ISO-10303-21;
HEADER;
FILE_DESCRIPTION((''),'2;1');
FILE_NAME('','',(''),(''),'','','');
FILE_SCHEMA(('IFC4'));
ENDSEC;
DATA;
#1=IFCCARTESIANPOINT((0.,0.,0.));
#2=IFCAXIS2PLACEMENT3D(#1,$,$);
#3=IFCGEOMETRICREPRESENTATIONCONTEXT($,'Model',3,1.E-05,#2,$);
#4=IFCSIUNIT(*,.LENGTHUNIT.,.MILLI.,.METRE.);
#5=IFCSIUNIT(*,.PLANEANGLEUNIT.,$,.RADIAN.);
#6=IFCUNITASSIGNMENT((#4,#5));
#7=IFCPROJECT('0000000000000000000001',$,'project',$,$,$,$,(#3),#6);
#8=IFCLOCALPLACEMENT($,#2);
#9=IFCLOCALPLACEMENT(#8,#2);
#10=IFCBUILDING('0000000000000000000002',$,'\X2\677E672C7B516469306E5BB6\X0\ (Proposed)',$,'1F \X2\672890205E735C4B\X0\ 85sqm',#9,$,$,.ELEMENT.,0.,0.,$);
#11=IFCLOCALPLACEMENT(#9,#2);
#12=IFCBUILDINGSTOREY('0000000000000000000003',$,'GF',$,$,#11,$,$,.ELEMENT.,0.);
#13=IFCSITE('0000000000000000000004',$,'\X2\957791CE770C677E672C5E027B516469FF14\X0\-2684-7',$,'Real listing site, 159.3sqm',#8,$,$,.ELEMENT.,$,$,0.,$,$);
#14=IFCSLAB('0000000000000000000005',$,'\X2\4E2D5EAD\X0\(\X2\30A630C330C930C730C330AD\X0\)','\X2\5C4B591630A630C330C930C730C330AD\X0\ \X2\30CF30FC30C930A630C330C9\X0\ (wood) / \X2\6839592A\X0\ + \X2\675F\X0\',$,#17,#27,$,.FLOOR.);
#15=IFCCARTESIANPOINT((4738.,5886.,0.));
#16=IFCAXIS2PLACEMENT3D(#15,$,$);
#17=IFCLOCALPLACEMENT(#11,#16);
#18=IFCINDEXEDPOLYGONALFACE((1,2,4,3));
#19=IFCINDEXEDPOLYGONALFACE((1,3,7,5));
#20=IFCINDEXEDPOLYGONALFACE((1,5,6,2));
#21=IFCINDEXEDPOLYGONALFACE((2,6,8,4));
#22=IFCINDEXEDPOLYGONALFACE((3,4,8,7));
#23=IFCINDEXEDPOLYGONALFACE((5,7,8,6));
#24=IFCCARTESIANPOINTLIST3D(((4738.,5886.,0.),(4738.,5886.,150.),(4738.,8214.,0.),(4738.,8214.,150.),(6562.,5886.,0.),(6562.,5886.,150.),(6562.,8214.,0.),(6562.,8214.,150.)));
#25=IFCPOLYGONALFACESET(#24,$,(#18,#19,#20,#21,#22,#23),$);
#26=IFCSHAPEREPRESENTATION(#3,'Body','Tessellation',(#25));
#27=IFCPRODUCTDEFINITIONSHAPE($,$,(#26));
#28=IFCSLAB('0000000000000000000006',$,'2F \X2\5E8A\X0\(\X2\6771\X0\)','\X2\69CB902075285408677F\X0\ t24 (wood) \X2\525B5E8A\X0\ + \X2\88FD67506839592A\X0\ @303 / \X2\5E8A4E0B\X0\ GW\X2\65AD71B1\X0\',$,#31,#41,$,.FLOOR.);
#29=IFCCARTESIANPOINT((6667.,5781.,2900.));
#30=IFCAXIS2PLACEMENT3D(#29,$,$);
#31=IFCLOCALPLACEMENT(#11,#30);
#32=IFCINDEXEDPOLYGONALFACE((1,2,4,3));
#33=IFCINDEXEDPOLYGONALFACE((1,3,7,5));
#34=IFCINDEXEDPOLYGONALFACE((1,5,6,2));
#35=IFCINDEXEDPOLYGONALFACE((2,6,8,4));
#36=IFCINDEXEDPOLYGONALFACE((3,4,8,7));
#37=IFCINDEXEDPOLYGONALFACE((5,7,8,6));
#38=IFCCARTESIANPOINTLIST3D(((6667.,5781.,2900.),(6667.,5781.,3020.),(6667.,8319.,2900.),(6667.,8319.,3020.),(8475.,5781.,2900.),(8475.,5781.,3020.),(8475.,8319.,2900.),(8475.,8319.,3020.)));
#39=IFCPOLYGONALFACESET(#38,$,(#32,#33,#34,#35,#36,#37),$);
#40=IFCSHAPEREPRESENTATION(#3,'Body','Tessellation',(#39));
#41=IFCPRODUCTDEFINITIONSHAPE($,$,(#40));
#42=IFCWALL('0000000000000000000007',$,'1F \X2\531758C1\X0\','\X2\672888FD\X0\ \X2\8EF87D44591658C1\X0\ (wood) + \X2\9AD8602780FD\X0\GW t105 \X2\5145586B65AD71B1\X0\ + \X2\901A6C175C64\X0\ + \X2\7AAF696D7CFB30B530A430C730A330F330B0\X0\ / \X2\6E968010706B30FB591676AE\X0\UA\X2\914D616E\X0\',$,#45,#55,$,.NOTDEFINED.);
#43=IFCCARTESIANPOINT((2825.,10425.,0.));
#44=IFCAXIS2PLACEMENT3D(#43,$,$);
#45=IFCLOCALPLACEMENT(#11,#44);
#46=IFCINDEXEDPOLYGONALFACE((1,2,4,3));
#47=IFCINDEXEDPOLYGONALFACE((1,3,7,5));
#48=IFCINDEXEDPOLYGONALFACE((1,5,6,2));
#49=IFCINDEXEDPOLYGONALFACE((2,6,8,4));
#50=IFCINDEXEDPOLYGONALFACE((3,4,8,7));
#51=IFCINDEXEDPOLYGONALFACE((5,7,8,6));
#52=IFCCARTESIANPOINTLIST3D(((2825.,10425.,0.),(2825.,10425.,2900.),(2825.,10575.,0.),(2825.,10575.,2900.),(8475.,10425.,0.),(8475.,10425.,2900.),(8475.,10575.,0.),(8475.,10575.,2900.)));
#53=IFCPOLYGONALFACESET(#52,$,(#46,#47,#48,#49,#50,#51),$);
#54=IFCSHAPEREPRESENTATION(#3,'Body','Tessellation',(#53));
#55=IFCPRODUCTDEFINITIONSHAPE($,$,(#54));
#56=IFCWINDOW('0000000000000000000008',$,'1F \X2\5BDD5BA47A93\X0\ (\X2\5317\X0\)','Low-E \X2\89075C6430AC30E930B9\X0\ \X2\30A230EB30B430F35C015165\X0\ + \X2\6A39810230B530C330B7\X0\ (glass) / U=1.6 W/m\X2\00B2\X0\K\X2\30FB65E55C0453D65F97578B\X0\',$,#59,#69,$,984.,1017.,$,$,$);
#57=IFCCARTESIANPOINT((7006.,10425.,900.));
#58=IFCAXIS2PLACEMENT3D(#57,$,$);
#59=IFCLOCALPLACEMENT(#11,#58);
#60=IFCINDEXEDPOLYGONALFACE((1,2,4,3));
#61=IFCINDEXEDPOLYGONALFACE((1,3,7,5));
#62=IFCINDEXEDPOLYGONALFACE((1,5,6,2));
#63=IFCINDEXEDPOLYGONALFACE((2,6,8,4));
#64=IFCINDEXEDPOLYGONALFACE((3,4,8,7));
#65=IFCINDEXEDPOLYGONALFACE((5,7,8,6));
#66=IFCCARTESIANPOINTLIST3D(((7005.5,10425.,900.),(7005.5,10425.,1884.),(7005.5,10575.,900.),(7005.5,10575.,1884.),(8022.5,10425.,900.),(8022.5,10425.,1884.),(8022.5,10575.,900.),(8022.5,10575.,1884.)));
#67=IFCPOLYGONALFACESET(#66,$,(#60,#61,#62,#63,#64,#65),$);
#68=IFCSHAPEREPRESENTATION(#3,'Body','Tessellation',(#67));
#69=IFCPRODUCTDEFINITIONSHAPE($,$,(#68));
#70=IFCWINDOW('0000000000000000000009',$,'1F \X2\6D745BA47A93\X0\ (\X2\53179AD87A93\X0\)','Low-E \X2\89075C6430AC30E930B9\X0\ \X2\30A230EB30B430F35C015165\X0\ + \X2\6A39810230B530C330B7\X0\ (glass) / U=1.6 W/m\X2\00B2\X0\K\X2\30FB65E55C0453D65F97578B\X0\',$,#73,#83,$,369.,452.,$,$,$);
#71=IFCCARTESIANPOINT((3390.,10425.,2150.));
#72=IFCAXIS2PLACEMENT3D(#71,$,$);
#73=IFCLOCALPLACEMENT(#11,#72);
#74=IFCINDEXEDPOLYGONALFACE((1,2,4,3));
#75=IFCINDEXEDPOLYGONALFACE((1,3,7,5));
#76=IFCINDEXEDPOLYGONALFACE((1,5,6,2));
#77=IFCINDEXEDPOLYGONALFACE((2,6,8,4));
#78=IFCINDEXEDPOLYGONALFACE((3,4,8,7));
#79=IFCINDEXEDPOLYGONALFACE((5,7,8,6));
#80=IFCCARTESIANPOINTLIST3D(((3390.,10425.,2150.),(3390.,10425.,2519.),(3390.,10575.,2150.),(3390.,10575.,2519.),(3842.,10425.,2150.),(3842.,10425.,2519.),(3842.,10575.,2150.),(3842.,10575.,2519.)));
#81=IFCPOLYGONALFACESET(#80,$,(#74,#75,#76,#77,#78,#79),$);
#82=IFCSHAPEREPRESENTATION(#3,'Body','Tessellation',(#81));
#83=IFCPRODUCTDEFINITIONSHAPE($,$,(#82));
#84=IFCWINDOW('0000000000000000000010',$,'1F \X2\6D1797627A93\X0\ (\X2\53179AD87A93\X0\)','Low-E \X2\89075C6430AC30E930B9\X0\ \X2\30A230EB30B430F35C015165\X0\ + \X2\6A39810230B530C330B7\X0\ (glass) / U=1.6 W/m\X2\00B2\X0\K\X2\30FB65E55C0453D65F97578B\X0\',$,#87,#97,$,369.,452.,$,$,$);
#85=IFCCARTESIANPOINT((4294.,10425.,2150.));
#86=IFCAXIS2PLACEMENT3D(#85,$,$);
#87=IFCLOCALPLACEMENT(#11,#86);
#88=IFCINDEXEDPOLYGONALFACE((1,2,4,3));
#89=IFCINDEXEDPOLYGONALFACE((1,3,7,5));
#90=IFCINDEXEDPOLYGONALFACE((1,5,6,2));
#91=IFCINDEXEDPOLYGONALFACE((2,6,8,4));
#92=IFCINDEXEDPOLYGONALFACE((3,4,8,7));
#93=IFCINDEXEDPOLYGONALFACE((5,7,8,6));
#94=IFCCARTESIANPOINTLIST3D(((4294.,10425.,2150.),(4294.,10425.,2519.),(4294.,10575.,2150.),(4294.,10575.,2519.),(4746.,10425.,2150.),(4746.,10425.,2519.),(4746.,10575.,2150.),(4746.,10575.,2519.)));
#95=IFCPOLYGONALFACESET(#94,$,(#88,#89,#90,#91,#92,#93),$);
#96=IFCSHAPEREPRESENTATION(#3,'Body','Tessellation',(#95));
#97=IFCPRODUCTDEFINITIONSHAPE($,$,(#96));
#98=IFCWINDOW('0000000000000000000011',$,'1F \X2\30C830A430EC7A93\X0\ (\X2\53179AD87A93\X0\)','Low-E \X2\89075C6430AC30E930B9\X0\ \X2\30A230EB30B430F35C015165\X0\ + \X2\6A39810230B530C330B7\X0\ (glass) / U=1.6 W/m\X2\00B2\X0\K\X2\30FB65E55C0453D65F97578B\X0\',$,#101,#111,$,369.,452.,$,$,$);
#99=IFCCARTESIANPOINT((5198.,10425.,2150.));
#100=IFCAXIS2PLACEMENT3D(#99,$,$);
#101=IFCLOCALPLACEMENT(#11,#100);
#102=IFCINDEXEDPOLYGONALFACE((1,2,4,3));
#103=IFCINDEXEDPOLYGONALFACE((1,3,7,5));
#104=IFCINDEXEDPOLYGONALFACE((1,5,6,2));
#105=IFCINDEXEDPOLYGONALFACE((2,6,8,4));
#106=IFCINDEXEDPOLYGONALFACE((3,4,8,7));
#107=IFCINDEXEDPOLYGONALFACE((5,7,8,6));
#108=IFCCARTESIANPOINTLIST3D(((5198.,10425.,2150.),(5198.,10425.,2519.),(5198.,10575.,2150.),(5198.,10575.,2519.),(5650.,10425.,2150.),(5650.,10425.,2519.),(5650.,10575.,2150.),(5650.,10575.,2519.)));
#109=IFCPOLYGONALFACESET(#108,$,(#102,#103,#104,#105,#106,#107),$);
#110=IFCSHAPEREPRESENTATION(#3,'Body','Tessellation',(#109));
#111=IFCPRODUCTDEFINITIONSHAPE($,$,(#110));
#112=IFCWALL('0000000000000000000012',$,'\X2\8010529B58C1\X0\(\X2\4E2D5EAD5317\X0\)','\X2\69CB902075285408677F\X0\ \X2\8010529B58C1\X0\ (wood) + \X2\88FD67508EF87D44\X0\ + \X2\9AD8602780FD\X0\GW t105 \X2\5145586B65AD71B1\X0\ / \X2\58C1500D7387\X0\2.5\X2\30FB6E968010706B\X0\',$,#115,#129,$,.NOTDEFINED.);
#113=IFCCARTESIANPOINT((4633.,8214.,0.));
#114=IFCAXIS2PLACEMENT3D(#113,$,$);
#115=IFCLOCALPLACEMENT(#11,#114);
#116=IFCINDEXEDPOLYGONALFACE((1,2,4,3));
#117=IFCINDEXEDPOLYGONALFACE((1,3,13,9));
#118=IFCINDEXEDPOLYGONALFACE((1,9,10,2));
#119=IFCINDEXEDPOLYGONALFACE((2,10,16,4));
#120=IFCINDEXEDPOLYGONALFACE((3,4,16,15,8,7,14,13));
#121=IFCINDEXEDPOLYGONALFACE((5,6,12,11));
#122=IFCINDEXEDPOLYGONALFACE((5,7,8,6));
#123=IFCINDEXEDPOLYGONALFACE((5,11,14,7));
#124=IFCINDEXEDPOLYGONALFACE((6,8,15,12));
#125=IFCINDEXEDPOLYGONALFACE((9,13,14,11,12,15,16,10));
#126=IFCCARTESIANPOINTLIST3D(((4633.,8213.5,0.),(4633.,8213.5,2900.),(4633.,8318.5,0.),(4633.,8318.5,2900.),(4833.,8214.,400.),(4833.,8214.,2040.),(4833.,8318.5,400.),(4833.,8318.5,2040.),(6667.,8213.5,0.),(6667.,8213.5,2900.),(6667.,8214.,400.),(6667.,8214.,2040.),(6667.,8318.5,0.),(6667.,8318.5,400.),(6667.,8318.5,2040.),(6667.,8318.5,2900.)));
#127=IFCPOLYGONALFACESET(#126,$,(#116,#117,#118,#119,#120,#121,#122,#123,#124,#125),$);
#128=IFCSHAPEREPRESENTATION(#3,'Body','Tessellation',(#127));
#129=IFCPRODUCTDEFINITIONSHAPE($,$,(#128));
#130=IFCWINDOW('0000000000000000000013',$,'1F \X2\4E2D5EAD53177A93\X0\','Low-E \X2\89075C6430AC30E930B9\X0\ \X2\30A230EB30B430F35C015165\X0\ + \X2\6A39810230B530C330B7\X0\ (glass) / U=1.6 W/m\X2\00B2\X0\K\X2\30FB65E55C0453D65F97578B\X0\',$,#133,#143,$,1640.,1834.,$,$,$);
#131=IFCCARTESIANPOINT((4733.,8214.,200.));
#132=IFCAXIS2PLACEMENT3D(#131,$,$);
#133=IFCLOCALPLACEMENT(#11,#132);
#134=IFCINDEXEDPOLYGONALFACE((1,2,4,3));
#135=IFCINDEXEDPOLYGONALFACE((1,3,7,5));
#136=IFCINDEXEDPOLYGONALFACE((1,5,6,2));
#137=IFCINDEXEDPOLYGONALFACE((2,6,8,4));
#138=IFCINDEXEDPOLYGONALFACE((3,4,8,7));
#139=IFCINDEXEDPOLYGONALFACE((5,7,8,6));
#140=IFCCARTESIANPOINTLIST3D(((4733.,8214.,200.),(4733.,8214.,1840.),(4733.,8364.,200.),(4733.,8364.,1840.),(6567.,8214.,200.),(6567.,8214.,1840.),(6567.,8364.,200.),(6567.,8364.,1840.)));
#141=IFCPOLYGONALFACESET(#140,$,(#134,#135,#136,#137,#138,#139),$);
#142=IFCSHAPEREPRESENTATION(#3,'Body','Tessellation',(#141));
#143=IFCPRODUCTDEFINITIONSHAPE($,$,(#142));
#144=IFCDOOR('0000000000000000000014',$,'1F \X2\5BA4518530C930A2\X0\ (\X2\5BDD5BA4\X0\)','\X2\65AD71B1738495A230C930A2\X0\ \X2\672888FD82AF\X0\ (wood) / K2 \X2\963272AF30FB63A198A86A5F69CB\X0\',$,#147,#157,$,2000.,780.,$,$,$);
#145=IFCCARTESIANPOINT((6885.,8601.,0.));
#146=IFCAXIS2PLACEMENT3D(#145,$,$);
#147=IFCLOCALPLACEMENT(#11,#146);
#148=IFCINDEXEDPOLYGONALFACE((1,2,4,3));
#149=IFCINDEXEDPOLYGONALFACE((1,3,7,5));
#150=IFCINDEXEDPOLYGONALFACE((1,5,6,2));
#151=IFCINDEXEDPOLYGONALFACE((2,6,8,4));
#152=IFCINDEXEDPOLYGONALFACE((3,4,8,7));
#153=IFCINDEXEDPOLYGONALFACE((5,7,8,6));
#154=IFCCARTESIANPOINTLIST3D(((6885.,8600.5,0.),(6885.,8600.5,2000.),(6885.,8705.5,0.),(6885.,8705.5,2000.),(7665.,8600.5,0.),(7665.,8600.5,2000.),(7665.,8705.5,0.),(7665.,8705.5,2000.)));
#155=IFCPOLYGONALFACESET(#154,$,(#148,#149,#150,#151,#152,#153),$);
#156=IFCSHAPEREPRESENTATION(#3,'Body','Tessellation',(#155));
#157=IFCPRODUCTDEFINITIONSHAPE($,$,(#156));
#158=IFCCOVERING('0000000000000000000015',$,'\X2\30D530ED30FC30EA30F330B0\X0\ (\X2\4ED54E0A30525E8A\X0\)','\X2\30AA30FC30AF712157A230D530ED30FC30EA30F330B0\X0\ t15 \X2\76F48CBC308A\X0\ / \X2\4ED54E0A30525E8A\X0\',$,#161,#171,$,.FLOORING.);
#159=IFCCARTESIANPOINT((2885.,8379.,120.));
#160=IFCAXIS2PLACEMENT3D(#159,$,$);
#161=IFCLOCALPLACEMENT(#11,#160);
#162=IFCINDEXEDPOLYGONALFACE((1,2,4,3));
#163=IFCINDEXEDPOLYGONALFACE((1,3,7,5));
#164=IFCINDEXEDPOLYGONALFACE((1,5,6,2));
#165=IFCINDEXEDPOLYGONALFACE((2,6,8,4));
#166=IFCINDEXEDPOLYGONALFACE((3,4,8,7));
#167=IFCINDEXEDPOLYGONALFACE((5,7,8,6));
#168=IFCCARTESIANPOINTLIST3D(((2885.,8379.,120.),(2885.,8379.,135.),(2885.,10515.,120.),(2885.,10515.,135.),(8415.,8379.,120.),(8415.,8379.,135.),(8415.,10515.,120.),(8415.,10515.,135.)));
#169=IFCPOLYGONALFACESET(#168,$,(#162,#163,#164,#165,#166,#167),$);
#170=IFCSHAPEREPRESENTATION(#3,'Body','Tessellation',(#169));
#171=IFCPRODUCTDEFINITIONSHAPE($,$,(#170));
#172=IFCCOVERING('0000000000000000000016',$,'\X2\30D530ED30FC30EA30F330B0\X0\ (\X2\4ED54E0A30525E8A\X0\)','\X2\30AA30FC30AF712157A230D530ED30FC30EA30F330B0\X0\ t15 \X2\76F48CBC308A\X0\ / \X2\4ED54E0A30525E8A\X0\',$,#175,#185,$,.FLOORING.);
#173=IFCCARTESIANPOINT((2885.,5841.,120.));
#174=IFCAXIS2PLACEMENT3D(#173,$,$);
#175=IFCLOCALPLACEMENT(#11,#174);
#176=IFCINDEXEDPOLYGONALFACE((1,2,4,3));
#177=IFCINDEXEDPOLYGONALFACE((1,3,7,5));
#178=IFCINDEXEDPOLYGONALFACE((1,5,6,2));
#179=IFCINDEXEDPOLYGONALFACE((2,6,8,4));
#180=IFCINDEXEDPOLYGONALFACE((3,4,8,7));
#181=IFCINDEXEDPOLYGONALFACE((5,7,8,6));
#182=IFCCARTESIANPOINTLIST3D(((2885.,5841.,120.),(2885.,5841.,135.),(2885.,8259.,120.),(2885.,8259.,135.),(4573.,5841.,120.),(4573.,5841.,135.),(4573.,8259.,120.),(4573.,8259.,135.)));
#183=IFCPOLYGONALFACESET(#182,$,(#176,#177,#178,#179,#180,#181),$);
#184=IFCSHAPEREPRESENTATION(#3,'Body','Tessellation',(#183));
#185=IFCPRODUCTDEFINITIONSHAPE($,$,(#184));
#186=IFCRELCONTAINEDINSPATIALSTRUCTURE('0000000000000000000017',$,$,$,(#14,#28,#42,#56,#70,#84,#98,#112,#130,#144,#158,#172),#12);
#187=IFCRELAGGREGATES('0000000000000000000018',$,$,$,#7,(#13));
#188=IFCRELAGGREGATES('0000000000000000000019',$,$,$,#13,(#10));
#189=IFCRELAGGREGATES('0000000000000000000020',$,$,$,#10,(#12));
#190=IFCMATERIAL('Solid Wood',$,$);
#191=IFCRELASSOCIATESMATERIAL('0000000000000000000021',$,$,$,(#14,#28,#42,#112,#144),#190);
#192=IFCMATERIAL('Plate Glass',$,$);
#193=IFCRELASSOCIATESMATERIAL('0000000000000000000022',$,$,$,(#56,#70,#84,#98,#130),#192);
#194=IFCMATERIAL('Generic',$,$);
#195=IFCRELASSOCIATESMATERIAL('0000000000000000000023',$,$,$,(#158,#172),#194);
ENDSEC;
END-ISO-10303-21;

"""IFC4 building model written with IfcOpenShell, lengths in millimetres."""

from ifc_helpers import new_model, si_unit, frame, frame_2d, origin, place, context, project, spatial, rectangle, extrude, material, element, fill, save


model = new_model("IFC4")

# Units and contexts
model_context = context("Model", 3, precision=1e-05, world=origin())
ifc_project = project(units=[si_unit("LENGTHUNIT", "METRE", prefix="MILLI"), si_unit("PLANEANGLEUNIT", "RADIAN")], contexts=[model_context])

# Site, building, storey
site_placement = place(None, origin())
site = spatial("IfcSite", under=ifc_project, at=site_placement, Name="長野県松本市筑摩４-2684-7", ObjectType="Real listing site, 159.3sqm", CompositionType="ELEMENT", RefElevation=0.0)
building_placement = place(site_placement, origin())
building = spatial("IfcBuilding", under=site, at=building_placement, Name="松本筑摩の家 (Proposed)", ObjectType="1F 木造平屋 85sqm", CompositionType="ELEMENT", ElevationOfRefHeight=0.0, ElevationOfTerrain=0.0)
storey_placement = place(building_placement, origin())
storey = spatial("IfcBuildingStorey", under=building, at=storey_placement, Name="GF", CompositionType="ELEMENT", Elevation=0.0)

# Slabs
ifc_material_1 = material(Name="Solid Wood")
slab_1_placement = place(storey_placement, frame((4738.0, 5886.0, 0.0)))
element("IfcSlab", 1, at=slab_1_placement, inside=storey, material=ifc_material_1, Name="中庭(ウッドデッキ)", Description="屋外ウッドデッキ ハードウッド (wood) / 根太 + 束", PredefinedType="FLOOR", context=model_context, shape_type="SweptSolid", body=[
    extrude(rectangle(XDim=1824.0, YDim=2328.0, at=frame_2d((912.0, 1164.0))), frame((4738.0, 5886.0, 0.0)), (0.0, 0.0, 1.0), 150.0),
])
slab_2_placement = place(storey_placement, frame((6667.0, 5781.0, 2900.0)))
element("IfcSlab", 2, at=slab_2_placement, inside=storey, material=ifc_material_1, Name="2F 床(東)", Description="構造用合板 t24 (wood) 剛床 + 製材根太 @303 / 床下 GW断熱", PredefinedType="FLOOR", context=model_context, shape_type="SweptSolid", body=[
    extrude(rectangle(XDim=1808.0, YDim=2538.0, at=frame_2d((904.0, 1269.0))), frame((6667.0, 5781.0, 2900.0)), (0.0, 0.0, 1.0), 120.0),
])

# Wall, openings, windows
wall_1_placement = place(storey_placement, frame((2825.0, 10425.0, 0.0)))
wall_1 = element("IfcWall", 3, at=wall_1_placement, inside=storey, material=ifc_material_1, Name="1F 北壁", Description="木製 軸組外壁 (wood) + 高性能GW t105 充填断熱 + 通気層 + 窯業系サイディング / 準耐火・外皮UA配慮", PredefinedType="NOTDEFINED", context=model_context, shape_type="SweptSolid", body=[
    extrude(rectangle(XDim=5650.0, YDim=150.0, at=frame_2d((2825.0, 75.0))), frame((2825.0, 10425.0, 0.0)), (0.0, 0.0, 1.0), 2900.0),
])
opening_1_placement = place(storey_placement, frame((7006.0, 10425.0, 900.0)))
opening_1 = element("IfcOpeningElement", 4, at=opening_1_placement, cuts=wall_1, PredefinedType="NOTDEFINED", context=model_context, shape_type="SweptSolid", body=[
    extrude(rectangle(XDim=1017.0, YDim=150.0, at=frame_2d((508.0, 75.0))), frame((7006.0, 10425.0, 900.0)), (0.0, 0.0, 1.0), 984.0),
])
opening_2_placement = place(storey_placement, frame((3390.0, 10425.0, 2150.0)))
opening_2 = element("IfcOpeningElement", 5, at=opening_2_placement, cuts=wall_1, PredefinedType="NOTDEFINED", context=model_context, shape_type="SweptSolid", body=[
    extrude(rectangle(XDim=452.0, YDim=150.0, at=frame_2d((226.0, 75.0))), frame((3390.0, 10425.0, 2150.0)), (0.0, 0.0, 1.0), 369.0),
])
opening_3_placement = place(storey_placement, frame((4294.0, 10425.0, 2150.0)))
opening_3 = element("IfcOpeningElement", 6, at=opening_3_placement, cuts=wall_1, PredefinedType="NOTDEFINED", context=model_context, shape_type="SweptSolid", body=[
    extrude(rectangle(XDim=452.0, YDim=150.0, at=frame_2d((226.0, 75.0))), frame((4294.0, 10425.0, 2150.0)), (0.0, 0.0, 1.0), 369.0),
])
opening_4_placement = place(storey_placement, frame((5198.0, 10425.0, 2150.0)))
opening_4 = element("IfcOpeningElement", 7, at=opening_4_placement, cuts=wall_1, PredefinedType="NOTDEFINED", context=model_context, shape_type="SweptSolid", body=[
    extrude(rectangle(XDim=452.0, YDim=150.0, at=frame_2d((226.0, 75.0))), frame((5198.0, 10425.0, 2150.0)), (0.0, 0.0, 1.0), 369.0),
])
ifc_material_2 = material(Name="Plate Glass")
window_1_placement = place(storey_placement, frame((7006.0, 10425.0, 900.0)))
window_1 = element("IfcWindow", 8, at=window_1_placement, inside=storey, material=ifc_material_2, Name="1F 寝室窓 (北)", Description="Low-E 複層ガラス アルゴン封入 + 樹脂サッシ (glass) / U=1.6 W/m²K・日射取得型", OverallHeight=984.0, OverallWidth=1017.0, context=model_context, shape_type="SweptSolid", body=[
    extrude(rectangle(XDim=1017.0, YDim=150.0, at=frame_2d((508.0, 75.0))), frame((7006.0, 10425.0, 900.0)), (0.0, 0.0, 1.0), 984.0),
])
fill(opening_1, window_1)
window_2_placement = place(storey_placement, frame((3390.0, 10425.0, 2150.0)))
window_2 = element("IfcWindow", 9, at=window_2_placement, inside=storey, material=ifc_material_2, Name="1F 浴室窓 (北高窓)", Description="Low-E 複層ガラス アルゴン封入 + 樹脂サッシ (glass) / U=1.6 W/m²K・日射取得型", OverallHeight=369.0, OverallWidth=452.0, context=model_context, shape_type="SweptSolid", body=[
    extrude(rectangle(XDim=452.0, YDim=150.0, at=frame_2d((226.0, 75.0))), frame((3390.0, 10425.0, 2150.0)), (0.0, 0.0, 1.0), 369.0),
])
fill(opening_2, window_2)
window_3_placement = place(storey_placement, frame((4294.0, 10425.0, 2150.0)))
window_3 = element("IfcWindow", 10, at=window_3_placement, inside=storey, material=ifc_material_2, Name="1F 洗面窓 (北高窓)", Description="Low-E 複層ガラス アルゴン封入 + 樹脂サッシ (glass) / U=1.6 W/m²K・日射取得型", OverallHeight=369.0, OverallWidth=452.0, context=model_context, shape_type="SweptSolid", body=[
    extrude(rectangle(XDim=452.0, YDim=150.0, at=frame_2d((226.0, 75.0))), frame((4294.0, 10425.0, 2150.0)), (0.0, 0.0, 1.0), 369.0),
])
fill(opening_3, window_3)
window_4_placement = place(storey_placement, frame((5198.0, 10425.0, 2150.0)))
window_4 = element("IfcWindow", 11, at=window_4_placement, inside=storey, material=ifc_material_2, Name="1F トイレ窓 (北高窓)", Description="Low-E 複層ガラス アルゴン封入 + 樹脂サッシ (glass) / U=1.6 W/m²K・日射取得型", OverallHeight=369.0, OverallWidth=452.0, context=model_context, shape_type="SweptSolid", body=[
    extrude(rectangle(XDim=452.0, YDim=150.0, at=frame_2d((226.0, 75.0))), frame((5198.0, 10425.0, 2150.0)), (0.0, 0.0, 1.0), 369.0),
])
fill(opening_4, window_4)

# Wall, opening, window
wall_2_placement = place(storey_placement, frame((4633.0, 8214.0, 0.0)))
wall_2 = element("IfcWall", 12, at=wall_2_placement, inside=storey, material=ifc_material_1, Name="耐力壁(中庭北)", Description="構造用合板 耐力壁 (wood) + 製材軸組 + 高性能GW t105 充填断熱 / 壁倍率2.5・準耐火", PredefinedType="NOTDEFINED", context=model_context, shape_type="SweptSolid", body=[
    extrude(rectangle(XDim=2034.0, YDim=105.0, at=frame_2d((1017.0, 52.0))), frame((4633.0, 8214.0, 0.0)), (0.0, 0.0, 1.0), 2900.0),
])
opening_5_placement = place(storey_placement, frame((4733.0, 8214.0, 200.0)))
opening_5 = element("IfcOpeningElement", 13, at=opening_5_placement, cuts=wall_2, PredefinedType="NOTDEFINED", context=model_context, shape_type="SweptSolid", body=[
    extrude(rectangle(XDim=1834.0, YDim=150.0, at=frame_2d((917.0, 75.0))), frame((4733.0, 8214.0, 200.0)), (0.0, 0.0, 1.0), 1640.0),
])
window_5_placement = place(storey_placement, frame((4733.0, 8214.0, 200.0)))
window_5 = element("IfcWindow", 14, at=window_5_placement, inside=storey, material=ifc_material_2, Name="1F 中庭北窓", Description="Low-E 複層ガラス アルゴン封入 + 樹脂サッシ (glass) / U=1.6 W/m²K・日射取得型", OverallHeight=1640.0, OverallWidth=1834.0, context=model_context, shape_type="SweptSolid", body=[
    extrude(rectangle(XDim=1834.0, YDim=150.0, at=frame_2d((917.0, 75.0))), frame((4733.0, 8214.0, 200.0)), (0.0, 0.0, 1.0), 1640.0),
])
fill(opening_5, window_5)

# Door
door_1_placement = place(storey_placement, frame((6885.0, 8601.0, 0.0)))
element("IfcDoor", 15, at=door_1_placement, inside=storey, material=ifc_material_1, Name="1F 室内ドア (寝室)", Description="断熱玄関ドア 木製芯 (wood) / K2 防犯・採風機構", OverallHeight=2000.0, OverallWidth=780.0, context=model_context, shape_type="SweptSolid", body=[
    extrude(rectangle(XDim=780.0, YDim=105.0, at=frame_2d((390.0, 52.0))), frame((6885.0, 8601.0, 0.0)), (0.0, 0.0, 1.0), 2000.0),
])

# Coverings
ifc_material_3 = material(Name="Generic")
covering_1_placement = place(storey_placement, frame((2885.0, 8379.0, 120.0)))
element("IfcCovering", 16, at=covering_1_placement, inside=storey, material=ifc_material_3, Name="フローリング (仕上げ床)", Description="オーク無垢フローリング t15 直貼り / 仕上げ床", PredefinedType="FLOORING", context=model_context, shape_type="SweptSolid", body=[
    extrude(rectangle(XDim=5530.0, YDim=2136.0, at=frame_2d((2765.0, 1068.0))), frame((2885.0, 8379.0, 120.0)), (0.0, 0.0, 1.0), 15.0),
])
covering_2_placement = place(storey_placement, frame((2885.0, 5841.0, 120.0)))
element("IfcCovering", 17, at=covering_2_placement, inside=storey, material=ifc_material_3, Name="フローリング (仕上げ床)", Description="オーク無垢フローリング t15 直貼り / 仕上げ床", PredefinedType="FLOORING", context=model_context, shape_type="SweptSolid", body=[
    extrude(rectangle(XDim=1688.0, YDim=2418.0, at=frame_2d((844.0, 1209.0))), frame((2885.0, 5841.0, 120.0)), (0.0, 0.0, 1.0), 15.0),
])

save(model, "model.ifc")
